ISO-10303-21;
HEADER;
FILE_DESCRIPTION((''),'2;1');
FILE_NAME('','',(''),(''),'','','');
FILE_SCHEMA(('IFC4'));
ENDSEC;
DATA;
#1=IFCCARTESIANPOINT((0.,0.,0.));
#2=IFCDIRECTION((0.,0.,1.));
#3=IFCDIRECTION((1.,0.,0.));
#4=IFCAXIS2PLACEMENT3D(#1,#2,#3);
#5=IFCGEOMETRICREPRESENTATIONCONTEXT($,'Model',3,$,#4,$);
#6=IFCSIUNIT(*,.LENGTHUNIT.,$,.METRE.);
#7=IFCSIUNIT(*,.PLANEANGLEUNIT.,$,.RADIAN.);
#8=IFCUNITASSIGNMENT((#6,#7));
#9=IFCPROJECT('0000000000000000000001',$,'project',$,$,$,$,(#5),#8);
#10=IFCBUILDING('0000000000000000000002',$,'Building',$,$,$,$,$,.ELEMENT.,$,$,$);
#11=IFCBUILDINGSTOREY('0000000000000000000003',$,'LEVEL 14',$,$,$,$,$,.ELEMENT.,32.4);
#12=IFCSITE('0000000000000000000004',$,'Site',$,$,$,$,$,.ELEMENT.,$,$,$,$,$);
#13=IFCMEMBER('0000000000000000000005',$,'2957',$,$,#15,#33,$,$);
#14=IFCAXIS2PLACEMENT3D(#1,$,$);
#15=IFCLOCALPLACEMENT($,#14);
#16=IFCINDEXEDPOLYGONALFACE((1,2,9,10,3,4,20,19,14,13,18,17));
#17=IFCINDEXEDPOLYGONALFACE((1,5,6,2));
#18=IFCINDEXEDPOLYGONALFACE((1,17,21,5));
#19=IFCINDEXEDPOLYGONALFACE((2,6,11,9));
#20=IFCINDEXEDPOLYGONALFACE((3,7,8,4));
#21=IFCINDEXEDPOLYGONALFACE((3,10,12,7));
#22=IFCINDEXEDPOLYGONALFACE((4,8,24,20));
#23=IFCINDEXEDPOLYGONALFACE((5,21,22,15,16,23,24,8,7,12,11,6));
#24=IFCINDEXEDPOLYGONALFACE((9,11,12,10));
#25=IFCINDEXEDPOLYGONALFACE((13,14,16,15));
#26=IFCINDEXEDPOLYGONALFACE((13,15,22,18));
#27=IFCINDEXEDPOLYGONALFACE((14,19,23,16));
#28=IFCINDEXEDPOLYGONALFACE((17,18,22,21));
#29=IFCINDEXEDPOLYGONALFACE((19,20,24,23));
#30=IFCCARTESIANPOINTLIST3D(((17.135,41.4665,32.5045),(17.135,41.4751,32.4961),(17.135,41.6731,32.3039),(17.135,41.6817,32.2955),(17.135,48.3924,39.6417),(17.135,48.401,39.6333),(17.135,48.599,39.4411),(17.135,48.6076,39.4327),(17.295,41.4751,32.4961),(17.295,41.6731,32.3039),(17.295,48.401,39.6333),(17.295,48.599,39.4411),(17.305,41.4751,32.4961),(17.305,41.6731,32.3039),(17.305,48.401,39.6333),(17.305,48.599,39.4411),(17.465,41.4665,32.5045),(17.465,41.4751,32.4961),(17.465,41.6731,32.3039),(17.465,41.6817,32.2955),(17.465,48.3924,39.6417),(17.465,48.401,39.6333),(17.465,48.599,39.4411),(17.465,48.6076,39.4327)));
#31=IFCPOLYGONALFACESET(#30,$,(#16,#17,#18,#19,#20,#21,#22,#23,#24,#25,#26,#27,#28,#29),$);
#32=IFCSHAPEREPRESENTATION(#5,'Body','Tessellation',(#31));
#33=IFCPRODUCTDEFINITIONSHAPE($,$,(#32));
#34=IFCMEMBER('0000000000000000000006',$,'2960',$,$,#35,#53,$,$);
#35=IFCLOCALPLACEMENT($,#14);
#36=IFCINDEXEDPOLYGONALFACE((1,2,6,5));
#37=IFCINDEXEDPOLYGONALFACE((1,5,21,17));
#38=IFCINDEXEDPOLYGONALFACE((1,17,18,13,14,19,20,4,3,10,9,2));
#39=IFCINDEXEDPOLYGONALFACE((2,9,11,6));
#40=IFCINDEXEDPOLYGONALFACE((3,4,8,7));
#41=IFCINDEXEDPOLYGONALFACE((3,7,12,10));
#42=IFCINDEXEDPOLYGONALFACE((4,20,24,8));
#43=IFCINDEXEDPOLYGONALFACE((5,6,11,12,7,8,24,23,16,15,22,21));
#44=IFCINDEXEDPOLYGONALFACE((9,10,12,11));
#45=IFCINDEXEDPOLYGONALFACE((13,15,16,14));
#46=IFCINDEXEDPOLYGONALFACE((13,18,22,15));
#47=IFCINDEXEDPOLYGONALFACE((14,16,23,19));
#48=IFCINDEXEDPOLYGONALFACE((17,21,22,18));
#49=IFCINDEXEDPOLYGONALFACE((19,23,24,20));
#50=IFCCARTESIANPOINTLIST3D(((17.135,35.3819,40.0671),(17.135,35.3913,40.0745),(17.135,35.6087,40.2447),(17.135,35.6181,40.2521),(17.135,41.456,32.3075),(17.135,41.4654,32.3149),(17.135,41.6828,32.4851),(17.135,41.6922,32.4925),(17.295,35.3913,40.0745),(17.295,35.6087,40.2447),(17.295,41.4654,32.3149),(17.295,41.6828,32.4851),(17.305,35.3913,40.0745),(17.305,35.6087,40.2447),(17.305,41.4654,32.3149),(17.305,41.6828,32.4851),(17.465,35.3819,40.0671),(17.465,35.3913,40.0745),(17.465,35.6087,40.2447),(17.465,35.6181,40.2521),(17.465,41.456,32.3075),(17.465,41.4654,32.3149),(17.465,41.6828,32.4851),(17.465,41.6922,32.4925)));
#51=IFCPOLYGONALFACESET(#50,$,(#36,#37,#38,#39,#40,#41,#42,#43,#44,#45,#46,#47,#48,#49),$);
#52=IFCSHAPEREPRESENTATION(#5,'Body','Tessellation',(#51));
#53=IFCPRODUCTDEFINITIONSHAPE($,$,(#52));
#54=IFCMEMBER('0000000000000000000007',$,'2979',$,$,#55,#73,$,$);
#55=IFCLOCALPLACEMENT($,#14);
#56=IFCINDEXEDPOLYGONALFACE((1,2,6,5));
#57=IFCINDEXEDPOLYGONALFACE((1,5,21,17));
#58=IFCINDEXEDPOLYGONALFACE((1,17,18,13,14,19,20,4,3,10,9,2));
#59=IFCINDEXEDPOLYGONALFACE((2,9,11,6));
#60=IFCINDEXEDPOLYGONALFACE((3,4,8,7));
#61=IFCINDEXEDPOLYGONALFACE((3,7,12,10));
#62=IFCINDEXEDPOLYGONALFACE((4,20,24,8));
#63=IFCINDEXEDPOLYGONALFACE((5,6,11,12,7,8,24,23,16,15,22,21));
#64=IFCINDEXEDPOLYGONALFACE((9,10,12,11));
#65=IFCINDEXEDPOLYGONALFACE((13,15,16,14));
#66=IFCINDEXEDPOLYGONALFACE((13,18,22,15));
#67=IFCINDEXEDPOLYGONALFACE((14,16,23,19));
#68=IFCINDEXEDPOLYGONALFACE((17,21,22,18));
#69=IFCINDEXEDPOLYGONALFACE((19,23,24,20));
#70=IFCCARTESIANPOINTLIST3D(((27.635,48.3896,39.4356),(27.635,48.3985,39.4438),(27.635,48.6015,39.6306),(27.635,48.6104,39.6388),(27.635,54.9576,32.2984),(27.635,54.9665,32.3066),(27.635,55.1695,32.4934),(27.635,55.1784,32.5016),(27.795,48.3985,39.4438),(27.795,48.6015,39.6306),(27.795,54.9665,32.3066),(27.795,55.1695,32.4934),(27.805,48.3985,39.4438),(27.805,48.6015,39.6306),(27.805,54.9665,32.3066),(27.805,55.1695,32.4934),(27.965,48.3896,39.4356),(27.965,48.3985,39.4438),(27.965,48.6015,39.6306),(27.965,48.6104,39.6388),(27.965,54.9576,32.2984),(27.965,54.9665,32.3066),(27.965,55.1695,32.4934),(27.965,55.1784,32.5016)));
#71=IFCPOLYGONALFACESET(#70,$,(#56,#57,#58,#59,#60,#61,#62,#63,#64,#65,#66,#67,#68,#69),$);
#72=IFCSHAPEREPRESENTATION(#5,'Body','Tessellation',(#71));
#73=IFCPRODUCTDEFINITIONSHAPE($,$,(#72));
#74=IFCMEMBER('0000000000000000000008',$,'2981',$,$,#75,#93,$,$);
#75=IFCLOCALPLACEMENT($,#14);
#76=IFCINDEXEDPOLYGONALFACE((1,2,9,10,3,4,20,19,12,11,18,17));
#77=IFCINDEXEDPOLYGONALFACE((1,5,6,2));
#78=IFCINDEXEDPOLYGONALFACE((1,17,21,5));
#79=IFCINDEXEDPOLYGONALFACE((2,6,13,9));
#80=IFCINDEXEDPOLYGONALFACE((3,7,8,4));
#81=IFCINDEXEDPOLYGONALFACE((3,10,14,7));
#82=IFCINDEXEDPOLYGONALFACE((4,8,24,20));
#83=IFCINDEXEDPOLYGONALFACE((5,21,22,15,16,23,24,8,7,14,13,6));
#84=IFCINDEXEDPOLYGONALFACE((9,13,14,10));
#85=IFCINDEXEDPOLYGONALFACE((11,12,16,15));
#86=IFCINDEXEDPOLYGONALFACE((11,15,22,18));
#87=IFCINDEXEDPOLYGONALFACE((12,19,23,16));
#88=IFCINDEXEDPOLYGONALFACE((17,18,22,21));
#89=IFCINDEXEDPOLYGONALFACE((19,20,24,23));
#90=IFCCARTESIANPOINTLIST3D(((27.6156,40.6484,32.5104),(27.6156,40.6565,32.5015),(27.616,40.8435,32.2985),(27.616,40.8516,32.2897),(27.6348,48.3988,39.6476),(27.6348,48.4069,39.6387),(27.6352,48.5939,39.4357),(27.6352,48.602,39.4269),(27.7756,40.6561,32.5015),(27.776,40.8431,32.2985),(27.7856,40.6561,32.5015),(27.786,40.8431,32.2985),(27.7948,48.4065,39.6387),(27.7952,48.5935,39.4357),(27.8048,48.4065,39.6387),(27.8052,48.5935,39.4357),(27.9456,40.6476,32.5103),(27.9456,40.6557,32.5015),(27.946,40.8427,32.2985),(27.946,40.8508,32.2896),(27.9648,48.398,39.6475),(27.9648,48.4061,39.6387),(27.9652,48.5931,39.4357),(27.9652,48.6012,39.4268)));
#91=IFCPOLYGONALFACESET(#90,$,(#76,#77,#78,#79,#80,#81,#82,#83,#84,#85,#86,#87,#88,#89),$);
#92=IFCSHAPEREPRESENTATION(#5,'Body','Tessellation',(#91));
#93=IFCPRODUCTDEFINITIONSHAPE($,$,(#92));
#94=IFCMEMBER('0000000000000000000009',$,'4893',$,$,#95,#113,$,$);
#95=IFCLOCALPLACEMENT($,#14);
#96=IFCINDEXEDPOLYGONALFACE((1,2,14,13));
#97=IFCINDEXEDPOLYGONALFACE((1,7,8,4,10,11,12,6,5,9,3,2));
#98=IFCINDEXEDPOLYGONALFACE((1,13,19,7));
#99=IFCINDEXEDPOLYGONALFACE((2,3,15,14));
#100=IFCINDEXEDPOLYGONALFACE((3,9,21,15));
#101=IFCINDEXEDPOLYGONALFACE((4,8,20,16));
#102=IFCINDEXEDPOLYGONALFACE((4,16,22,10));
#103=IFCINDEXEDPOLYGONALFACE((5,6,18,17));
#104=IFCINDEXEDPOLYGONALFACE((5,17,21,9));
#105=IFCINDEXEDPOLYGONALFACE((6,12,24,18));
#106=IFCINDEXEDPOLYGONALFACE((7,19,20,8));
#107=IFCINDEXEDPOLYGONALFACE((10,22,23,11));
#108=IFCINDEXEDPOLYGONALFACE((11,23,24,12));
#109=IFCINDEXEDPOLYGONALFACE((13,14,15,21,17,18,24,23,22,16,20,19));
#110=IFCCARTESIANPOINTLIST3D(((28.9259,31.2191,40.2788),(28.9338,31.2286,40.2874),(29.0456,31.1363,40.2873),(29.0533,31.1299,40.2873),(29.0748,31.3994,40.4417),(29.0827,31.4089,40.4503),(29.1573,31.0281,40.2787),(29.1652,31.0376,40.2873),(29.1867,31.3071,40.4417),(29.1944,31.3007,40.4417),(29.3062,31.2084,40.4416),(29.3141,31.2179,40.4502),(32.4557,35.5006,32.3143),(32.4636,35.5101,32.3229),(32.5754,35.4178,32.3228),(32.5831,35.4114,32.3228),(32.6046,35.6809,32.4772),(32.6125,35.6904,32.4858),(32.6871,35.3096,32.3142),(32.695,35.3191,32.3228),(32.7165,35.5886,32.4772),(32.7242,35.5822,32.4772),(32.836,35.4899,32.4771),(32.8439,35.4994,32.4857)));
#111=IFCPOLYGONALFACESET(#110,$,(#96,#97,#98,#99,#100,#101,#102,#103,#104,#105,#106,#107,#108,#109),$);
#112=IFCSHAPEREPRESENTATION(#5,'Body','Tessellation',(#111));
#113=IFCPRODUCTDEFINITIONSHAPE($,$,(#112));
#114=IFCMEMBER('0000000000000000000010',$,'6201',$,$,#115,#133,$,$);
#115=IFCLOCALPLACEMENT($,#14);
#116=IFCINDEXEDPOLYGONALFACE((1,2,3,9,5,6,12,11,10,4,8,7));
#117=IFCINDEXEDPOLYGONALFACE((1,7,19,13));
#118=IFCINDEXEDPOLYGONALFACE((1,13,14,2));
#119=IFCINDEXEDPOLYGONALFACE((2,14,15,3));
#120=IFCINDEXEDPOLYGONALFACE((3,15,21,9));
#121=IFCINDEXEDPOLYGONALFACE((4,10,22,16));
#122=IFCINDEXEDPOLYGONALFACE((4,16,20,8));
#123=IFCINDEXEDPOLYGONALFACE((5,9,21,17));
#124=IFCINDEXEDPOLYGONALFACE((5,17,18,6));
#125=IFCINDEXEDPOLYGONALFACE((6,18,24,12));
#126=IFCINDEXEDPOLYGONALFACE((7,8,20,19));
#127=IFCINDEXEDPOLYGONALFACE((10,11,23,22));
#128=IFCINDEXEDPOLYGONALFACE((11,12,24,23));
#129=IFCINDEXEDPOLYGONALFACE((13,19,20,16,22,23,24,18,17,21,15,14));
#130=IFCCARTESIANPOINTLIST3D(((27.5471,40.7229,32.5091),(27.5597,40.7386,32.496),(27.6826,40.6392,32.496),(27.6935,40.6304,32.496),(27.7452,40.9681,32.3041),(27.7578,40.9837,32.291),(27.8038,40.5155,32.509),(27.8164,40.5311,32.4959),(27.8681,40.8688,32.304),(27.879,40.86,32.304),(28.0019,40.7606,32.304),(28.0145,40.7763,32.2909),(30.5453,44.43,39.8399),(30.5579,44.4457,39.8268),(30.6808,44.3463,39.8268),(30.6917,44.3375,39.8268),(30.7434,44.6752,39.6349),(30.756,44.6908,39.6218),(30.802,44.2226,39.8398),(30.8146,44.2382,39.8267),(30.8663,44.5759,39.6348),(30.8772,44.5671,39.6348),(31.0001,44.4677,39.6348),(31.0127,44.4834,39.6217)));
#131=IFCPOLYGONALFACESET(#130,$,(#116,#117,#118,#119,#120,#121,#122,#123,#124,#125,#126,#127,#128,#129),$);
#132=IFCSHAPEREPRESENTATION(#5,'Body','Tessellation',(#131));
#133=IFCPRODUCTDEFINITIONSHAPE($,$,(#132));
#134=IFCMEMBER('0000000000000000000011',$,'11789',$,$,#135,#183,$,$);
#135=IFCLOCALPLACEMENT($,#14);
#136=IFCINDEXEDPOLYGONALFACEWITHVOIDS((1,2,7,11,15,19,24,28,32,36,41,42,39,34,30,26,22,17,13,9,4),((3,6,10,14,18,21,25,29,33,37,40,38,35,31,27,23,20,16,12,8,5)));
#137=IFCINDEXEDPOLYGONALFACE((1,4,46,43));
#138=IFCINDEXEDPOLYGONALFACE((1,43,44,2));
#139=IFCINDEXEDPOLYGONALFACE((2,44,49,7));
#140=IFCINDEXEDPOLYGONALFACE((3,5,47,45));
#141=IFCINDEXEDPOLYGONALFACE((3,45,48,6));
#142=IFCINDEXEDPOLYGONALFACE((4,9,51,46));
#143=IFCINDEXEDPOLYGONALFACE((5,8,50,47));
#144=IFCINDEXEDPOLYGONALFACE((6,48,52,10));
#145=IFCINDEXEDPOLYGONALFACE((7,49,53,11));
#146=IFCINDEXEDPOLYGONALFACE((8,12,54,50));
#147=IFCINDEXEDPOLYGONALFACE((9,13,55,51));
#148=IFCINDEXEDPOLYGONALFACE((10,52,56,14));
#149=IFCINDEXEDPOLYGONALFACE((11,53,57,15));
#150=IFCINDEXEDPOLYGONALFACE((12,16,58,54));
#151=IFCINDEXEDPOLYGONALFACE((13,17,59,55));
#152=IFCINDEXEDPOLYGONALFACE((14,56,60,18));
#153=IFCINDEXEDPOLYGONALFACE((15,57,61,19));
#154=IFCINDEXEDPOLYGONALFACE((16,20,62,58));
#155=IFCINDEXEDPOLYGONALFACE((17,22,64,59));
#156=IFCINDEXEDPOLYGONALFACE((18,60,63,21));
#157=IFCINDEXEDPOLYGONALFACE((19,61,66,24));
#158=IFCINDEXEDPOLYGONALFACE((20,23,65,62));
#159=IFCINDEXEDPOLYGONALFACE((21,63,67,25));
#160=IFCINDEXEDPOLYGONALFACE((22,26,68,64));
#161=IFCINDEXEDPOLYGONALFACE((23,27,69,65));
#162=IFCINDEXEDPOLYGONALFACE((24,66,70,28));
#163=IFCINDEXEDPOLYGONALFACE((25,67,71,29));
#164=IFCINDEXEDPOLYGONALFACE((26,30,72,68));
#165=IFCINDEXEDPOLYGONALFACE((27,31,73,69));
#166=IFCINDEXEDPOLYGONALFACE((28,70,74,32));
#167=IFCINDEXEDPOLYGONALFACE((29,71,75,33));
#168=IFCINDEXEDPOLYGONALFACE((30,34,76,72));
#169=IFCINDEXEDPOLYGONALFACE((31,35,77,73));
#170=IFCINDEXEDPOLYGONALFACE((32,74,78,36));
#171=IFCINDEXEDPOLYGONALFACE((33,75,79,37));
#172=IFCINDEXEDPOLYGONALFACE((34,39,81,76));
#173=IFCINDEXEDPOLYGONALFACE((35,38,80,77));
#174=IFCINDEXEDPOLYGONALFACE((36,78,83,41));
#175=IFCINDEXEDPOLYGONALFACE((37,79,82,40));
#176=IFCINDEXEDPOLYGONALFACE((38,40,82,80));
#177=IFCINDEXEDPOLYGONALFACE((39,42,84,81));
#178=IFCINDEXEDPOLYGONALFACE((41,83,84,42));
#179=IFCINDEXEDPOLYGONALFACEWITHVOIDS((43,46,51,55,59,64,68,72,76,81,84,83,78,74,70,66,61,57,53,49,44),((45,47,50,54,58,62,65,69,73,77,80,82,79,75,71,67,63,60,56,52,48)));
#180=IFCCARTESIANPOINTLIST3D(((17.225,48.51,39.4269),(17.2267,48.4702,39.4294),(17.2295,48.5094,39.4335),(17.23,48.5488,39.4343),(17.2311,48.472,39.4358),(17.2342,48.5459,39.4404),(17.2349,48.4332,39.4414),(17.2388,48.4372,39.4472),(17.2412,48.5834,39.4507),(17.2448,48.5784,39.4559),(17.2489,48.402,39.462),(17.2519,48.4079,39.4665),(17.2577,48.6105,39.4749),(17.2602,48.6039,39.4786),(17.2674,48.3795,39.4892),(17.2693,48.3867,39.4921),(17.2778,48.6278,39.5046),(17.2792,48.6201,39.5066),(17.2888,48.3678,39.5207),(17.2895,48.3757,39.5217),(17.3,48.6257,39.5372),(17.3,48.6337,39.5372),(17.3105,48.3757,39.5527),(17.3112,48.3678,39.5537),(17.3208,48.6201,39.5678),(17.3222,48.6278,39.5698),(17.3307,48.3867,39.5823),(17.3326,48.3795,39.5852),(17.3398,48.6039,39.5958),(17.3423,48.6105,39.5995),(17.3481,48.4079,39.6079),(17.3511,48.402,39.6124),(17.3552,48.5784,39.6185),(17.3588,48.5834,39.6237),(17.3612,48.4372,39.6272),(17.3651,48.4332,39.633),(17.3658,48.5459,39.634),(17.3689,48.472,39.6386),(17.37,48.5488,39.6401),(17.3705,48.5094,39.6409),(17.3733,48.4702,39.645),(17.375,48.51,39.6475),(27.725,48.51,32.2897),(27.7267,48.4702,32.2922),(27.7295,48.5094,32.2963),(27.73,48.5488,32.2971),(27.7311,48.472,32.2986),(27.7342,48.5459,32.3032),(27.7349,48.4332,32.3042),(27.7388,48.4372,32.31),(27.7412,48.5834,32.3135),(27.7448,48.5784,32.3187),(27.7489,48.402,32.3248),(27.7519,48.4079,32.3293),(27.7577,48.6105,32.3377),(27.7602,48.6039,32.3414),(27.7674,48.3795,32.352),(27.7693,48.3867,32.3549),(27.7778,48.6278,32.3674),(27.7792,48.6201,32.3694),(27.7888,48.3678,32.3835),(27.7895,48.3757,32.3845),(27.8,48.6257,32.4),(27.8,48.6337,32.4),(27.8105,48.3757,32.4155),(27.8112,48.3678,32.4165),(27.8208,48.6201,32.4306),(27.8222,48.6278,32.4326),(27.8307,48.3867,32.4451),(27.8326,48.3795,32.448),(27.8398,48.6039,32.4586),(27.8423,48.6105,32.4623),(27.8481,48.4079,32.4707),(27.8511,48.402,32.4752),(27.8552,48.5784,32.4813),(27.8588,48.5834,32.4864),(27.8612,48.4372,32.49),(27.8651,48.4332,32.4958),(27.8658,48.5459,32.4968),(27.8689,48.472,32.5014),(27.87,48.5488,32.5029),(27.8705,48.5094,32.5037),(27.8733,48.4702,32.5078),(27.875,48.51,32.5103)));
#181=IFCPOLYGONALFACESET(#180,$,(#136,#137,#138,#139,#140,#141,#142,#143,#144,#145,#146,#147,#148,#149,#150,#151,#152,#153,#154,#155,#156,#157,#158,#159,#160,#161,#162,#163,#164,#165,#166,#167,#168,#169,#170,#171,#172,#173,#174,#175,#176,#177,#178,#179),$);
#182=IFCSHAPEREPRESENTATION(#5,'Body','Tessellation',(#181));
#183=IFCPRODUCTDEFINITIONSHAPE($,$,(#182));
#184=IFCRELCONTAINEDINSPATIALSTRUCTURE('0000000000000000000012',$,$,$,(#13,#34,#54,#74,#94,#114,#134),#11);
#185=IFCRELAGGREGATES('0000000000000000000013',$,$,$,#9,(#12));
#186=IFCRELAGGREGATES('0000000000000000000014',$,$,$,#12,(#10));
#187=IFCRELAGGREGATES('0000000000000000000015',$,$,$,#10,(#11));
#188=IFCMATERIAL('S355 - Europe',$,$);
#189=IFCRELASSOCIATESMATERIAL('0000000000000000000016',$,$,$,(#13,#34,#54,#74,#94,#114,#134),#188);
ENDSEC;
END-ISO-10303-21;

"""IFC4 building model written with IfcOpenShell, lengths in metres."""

from ifc_helpers import new_model, si_unit, frame, origin_with_axes, origin_2d_with_axis, place, context, project, spatial, hollow_circle, i_section, extrude, material, material_profile, profile_set, profile_usage, element, save


model = new_model("IFC4")

# Units and contexts
model_context = context("Model", 3, world=origin_with_axes())
ifc_project = project(units=[si_unit("LENGTHUNIT", "METRE"), si_unit("PLANEANGLEUNIT", "RADIAN")], contexts=[model_context])

# Site, building, storey
site = spatial("IfcSite", under=ifc_project, Name="Site", CompositionType="ELEMENT")
building = spatial("IfcBuilding", under=site, Name="Building", CompositionType="ELEMENT")
storey = spatial("IfcBuildingStorey", under=building, Name="LEVEL 14", CompositionType="ELEMENT", Elevation=32.4)

# Shared definitions
ifc_material = material(Name="S355 - Europe")

# Members
ifc_material_profile_1 = material_profile(ifc_material, i_section(OverallWidth=0.33, OverallDepth=0.3, WebThickness=0.01, FlangeThickness=0.012, at=origin_2d_with_axis()))
ifc_profile_set_1 = profile_set([ifc_material_profile_1])
ifc_profile_usage_1 = profile_usage(ifc_profile_set_1, cardinal=10)
member_1_placement = place(None, frame((17.3, 48.5, 39.5372), z_axis=(0.0, -0.696404, -0.71765), x_axis=(1.0, 0.0, 0.0)))
element("IfcMember", 1, at=member_1_placement, inside=storey, material=ifc_profile_usage_1, Name="2957", context=model_context, shape_type="SweptSolid", body=[
    extrude(i_section(OverallWidth=0.33, OverallDepth=0.3, WebThickness=0.01, FlangeThickness=0.012, at=origin_2d_with_axis()), origin_with_axes(), (0.0, 0.0, 1.0), 9.9452),
])
ifc_material_profile_2 = material_profile(ifc_material, i_section(OverallWidth=0.33, OverallDepth=0.3, WebThickness=0.01, FlangeThickness=0.012, at=origin_2d_with_axis()))
ifc_profile_set_2 = profile_set([ifc_material_profile_2])
ifc_profile_usage_2 = profile_usage(ifc_profile_set_2, cardinal=10)
member_2_placement = place(None, frame((17.3, 41.5741, 32.4), z_axis=(0.0, -0.616394, 0.787438), x_axis=(1.0, 0.0, 0.0)))
element("IfcMember", 2, at=member_2_placement, inside=storey, material=ifc_profile_usage_2, Name="2960", context=model_context, shape_type="SweptSolid", body=[
    extrude(i_section(OverallWidth=0.33, OverallDepth=0.3, WebThickness=0.01, FlangeThickness=0.012, at=origin_2d_with_axis()), origin_with_axes(), (0.0, 0.0, 1.0), 9.8542),
])
ifc_material_profile_3 = material_profile(ifc_material, i_section(OverallWidth=0.33, OverallDepth=0.3, WebThickness=0.01, FlangeThickness=0.012, at=origin_2d_with_axis()))
ifc_profile_set_3 = profile_set([ifc_material_profile_3])
ifc_profile_usage_3 = profile_usage(ifc_profile_set_3, cardinal=10)
member_3_placement = place(None, frame((27.8, 55.068, 32.4), z_axis=(0.0, -0.677156, 0.73584), x_axis=(1.0, 0.0, 0.0)))
element("IfcMember", 3, at=member_3_placement, inside=storey, material=ifc_profile_usage_3, Name="2979", context=model_context, shape_type="SweptSolid", body=[
    extrude(i_section(OverallWidth=0.33, OverallDepth=0.3, WebThickness=0.01, FlangeThickness=0.012, at=origin_2d_with_axis()), origin_with_axes(), (0.0, 0.0, 1.0), 9.6994),
])
ifc_material_profile_4 = material_profile(ifc_material, i_section(OverallWidth=0.33, OverallDepth=0.3, WebThickness=0.01, FlangeThickness=0.012, at=origin_2d_with_axis()))
ifc_profile_set_4 = profile_set([ifc_material_profile_4])
ifc_profile_usage_4 = profile_usage(ifc_profile_set_4, cardinal=10)
member_4_placement = place(None, frame((27.8, 48.5, 39.5372), z_axis=(-0.001822, -0.735607, -0.677407), x_axis=(0.999997, -0.002337, 0.0)))
element("IfcMember", 4, at=member_4_placement, inside=storey, material=ifc_profile_usage_4, Name="2981", context=model_context, shape_type="SweptSolid", body=[
    extrude(i_section(OverallWidth=0.33, OverallDepth=0.3, WebThickness=0.01, FlangeThickness=0.012, at=origin_2d_with_axis()), origin_with_axes(), (0.0, 0.0, 1.0), 10.5361),
])
ifc_material_profile_5 = material_profile(ifc_material, i_section(OverallWidth=0.3, OverallDepth=0.3, WebThickness=0.01, FlangeThickness=0.015, at=origin_2d_with_axis()))
ifc_profile_set_5 = profile_set([ifc_material_profile_5])
ifc_profile_usage_5 = profile_usage(ifc_profile_set_5, cardinal=10)
member_5_placement = place(None, frame((32.6498, 35.5, 32.4), z_axis=(-0.363638, -0.441078, 0.820498), x_axis=(0.771137, -0.636669, 0.0)))
element("IfcMember", 5, at=member_5_placement, inside=storey, material=ifc_profile_usage_5, Name="4893", context=model_context, shape_type="SweptSolid", body=[
    extrude(i_section(OverallWidth=0.3, OverallDepth=0.3, WebThickness=0.01, FlangeThickness=0.015, at=origin_2d_with_axis()), origin_with_axes(), (0.0, 0.0, 1.0), 9.7069),
])
ifc_material_profile_6 = material_profile(ifc_material, i_section(OverallWidth=0.33, OverallDepth=0.4, WebThickness=0.014, FlangeThickness=0.024, at=origin_2d_with_axis()))
ifc_profile_set_6 = profile_set([ifc_material_profile_6])
ifc_profile_usage_6 = profile_usage(ifc_profile_set_6, cardinal=10)
member_6_placement = place(None, frame((27.7808, 40.7496, 32.4), z_axis=(0.342853, 0.423918, 0.838299), x_axis=(-0.777826, 0.62848, 0.0)))
element("IfcMember", 6, at=member_6_placement, inside=storey, material=ifc_profile_usage_6, Name="6201", context=model_context, shape_type="SweptSolid", body=[
    extrude(i_section(OverallWidth=0.33, OverallDepth=0.4, WebThickness=0.014, FlangeThickness=0.024, at=origin_2d_with_axis()), origin_with_axes(), (0.0, 0.0, 1.0), 8.7449),
])
ifc_material_profile_7 = material_profile(ifc_material, hollow_circle(Radius=0.1337, WallThickness=0.008, at=origin_2d_with_axis()))
ifc_profile_set_7 = profile_set([ifc_material_profile_7])
ifc_profile_usage_7 = profile_usage(ifc_profile_set_7, cardinal=10)
member_7_placement = place(None, frame((17.3, 48.5, 39.5372), z_axis=(0.827029, 0.0, -0.562159), x_axis=(0.0, 1.0, 0.0)))
element("IfcMember", 7, at=member_7_placement, inside=storey, material=ifc_profile_usage_7, Name="11789", context=model_context, shape_type="SweptSolid", body=[
    extrude(hollow_circle(Radius=0.1337, WallThickness=0.008, at=origin_2d_with_axis()), origin_with_axes(), (0.0, 0.0, 1.0), 12.696),
])

save(model, "model.ifc")
